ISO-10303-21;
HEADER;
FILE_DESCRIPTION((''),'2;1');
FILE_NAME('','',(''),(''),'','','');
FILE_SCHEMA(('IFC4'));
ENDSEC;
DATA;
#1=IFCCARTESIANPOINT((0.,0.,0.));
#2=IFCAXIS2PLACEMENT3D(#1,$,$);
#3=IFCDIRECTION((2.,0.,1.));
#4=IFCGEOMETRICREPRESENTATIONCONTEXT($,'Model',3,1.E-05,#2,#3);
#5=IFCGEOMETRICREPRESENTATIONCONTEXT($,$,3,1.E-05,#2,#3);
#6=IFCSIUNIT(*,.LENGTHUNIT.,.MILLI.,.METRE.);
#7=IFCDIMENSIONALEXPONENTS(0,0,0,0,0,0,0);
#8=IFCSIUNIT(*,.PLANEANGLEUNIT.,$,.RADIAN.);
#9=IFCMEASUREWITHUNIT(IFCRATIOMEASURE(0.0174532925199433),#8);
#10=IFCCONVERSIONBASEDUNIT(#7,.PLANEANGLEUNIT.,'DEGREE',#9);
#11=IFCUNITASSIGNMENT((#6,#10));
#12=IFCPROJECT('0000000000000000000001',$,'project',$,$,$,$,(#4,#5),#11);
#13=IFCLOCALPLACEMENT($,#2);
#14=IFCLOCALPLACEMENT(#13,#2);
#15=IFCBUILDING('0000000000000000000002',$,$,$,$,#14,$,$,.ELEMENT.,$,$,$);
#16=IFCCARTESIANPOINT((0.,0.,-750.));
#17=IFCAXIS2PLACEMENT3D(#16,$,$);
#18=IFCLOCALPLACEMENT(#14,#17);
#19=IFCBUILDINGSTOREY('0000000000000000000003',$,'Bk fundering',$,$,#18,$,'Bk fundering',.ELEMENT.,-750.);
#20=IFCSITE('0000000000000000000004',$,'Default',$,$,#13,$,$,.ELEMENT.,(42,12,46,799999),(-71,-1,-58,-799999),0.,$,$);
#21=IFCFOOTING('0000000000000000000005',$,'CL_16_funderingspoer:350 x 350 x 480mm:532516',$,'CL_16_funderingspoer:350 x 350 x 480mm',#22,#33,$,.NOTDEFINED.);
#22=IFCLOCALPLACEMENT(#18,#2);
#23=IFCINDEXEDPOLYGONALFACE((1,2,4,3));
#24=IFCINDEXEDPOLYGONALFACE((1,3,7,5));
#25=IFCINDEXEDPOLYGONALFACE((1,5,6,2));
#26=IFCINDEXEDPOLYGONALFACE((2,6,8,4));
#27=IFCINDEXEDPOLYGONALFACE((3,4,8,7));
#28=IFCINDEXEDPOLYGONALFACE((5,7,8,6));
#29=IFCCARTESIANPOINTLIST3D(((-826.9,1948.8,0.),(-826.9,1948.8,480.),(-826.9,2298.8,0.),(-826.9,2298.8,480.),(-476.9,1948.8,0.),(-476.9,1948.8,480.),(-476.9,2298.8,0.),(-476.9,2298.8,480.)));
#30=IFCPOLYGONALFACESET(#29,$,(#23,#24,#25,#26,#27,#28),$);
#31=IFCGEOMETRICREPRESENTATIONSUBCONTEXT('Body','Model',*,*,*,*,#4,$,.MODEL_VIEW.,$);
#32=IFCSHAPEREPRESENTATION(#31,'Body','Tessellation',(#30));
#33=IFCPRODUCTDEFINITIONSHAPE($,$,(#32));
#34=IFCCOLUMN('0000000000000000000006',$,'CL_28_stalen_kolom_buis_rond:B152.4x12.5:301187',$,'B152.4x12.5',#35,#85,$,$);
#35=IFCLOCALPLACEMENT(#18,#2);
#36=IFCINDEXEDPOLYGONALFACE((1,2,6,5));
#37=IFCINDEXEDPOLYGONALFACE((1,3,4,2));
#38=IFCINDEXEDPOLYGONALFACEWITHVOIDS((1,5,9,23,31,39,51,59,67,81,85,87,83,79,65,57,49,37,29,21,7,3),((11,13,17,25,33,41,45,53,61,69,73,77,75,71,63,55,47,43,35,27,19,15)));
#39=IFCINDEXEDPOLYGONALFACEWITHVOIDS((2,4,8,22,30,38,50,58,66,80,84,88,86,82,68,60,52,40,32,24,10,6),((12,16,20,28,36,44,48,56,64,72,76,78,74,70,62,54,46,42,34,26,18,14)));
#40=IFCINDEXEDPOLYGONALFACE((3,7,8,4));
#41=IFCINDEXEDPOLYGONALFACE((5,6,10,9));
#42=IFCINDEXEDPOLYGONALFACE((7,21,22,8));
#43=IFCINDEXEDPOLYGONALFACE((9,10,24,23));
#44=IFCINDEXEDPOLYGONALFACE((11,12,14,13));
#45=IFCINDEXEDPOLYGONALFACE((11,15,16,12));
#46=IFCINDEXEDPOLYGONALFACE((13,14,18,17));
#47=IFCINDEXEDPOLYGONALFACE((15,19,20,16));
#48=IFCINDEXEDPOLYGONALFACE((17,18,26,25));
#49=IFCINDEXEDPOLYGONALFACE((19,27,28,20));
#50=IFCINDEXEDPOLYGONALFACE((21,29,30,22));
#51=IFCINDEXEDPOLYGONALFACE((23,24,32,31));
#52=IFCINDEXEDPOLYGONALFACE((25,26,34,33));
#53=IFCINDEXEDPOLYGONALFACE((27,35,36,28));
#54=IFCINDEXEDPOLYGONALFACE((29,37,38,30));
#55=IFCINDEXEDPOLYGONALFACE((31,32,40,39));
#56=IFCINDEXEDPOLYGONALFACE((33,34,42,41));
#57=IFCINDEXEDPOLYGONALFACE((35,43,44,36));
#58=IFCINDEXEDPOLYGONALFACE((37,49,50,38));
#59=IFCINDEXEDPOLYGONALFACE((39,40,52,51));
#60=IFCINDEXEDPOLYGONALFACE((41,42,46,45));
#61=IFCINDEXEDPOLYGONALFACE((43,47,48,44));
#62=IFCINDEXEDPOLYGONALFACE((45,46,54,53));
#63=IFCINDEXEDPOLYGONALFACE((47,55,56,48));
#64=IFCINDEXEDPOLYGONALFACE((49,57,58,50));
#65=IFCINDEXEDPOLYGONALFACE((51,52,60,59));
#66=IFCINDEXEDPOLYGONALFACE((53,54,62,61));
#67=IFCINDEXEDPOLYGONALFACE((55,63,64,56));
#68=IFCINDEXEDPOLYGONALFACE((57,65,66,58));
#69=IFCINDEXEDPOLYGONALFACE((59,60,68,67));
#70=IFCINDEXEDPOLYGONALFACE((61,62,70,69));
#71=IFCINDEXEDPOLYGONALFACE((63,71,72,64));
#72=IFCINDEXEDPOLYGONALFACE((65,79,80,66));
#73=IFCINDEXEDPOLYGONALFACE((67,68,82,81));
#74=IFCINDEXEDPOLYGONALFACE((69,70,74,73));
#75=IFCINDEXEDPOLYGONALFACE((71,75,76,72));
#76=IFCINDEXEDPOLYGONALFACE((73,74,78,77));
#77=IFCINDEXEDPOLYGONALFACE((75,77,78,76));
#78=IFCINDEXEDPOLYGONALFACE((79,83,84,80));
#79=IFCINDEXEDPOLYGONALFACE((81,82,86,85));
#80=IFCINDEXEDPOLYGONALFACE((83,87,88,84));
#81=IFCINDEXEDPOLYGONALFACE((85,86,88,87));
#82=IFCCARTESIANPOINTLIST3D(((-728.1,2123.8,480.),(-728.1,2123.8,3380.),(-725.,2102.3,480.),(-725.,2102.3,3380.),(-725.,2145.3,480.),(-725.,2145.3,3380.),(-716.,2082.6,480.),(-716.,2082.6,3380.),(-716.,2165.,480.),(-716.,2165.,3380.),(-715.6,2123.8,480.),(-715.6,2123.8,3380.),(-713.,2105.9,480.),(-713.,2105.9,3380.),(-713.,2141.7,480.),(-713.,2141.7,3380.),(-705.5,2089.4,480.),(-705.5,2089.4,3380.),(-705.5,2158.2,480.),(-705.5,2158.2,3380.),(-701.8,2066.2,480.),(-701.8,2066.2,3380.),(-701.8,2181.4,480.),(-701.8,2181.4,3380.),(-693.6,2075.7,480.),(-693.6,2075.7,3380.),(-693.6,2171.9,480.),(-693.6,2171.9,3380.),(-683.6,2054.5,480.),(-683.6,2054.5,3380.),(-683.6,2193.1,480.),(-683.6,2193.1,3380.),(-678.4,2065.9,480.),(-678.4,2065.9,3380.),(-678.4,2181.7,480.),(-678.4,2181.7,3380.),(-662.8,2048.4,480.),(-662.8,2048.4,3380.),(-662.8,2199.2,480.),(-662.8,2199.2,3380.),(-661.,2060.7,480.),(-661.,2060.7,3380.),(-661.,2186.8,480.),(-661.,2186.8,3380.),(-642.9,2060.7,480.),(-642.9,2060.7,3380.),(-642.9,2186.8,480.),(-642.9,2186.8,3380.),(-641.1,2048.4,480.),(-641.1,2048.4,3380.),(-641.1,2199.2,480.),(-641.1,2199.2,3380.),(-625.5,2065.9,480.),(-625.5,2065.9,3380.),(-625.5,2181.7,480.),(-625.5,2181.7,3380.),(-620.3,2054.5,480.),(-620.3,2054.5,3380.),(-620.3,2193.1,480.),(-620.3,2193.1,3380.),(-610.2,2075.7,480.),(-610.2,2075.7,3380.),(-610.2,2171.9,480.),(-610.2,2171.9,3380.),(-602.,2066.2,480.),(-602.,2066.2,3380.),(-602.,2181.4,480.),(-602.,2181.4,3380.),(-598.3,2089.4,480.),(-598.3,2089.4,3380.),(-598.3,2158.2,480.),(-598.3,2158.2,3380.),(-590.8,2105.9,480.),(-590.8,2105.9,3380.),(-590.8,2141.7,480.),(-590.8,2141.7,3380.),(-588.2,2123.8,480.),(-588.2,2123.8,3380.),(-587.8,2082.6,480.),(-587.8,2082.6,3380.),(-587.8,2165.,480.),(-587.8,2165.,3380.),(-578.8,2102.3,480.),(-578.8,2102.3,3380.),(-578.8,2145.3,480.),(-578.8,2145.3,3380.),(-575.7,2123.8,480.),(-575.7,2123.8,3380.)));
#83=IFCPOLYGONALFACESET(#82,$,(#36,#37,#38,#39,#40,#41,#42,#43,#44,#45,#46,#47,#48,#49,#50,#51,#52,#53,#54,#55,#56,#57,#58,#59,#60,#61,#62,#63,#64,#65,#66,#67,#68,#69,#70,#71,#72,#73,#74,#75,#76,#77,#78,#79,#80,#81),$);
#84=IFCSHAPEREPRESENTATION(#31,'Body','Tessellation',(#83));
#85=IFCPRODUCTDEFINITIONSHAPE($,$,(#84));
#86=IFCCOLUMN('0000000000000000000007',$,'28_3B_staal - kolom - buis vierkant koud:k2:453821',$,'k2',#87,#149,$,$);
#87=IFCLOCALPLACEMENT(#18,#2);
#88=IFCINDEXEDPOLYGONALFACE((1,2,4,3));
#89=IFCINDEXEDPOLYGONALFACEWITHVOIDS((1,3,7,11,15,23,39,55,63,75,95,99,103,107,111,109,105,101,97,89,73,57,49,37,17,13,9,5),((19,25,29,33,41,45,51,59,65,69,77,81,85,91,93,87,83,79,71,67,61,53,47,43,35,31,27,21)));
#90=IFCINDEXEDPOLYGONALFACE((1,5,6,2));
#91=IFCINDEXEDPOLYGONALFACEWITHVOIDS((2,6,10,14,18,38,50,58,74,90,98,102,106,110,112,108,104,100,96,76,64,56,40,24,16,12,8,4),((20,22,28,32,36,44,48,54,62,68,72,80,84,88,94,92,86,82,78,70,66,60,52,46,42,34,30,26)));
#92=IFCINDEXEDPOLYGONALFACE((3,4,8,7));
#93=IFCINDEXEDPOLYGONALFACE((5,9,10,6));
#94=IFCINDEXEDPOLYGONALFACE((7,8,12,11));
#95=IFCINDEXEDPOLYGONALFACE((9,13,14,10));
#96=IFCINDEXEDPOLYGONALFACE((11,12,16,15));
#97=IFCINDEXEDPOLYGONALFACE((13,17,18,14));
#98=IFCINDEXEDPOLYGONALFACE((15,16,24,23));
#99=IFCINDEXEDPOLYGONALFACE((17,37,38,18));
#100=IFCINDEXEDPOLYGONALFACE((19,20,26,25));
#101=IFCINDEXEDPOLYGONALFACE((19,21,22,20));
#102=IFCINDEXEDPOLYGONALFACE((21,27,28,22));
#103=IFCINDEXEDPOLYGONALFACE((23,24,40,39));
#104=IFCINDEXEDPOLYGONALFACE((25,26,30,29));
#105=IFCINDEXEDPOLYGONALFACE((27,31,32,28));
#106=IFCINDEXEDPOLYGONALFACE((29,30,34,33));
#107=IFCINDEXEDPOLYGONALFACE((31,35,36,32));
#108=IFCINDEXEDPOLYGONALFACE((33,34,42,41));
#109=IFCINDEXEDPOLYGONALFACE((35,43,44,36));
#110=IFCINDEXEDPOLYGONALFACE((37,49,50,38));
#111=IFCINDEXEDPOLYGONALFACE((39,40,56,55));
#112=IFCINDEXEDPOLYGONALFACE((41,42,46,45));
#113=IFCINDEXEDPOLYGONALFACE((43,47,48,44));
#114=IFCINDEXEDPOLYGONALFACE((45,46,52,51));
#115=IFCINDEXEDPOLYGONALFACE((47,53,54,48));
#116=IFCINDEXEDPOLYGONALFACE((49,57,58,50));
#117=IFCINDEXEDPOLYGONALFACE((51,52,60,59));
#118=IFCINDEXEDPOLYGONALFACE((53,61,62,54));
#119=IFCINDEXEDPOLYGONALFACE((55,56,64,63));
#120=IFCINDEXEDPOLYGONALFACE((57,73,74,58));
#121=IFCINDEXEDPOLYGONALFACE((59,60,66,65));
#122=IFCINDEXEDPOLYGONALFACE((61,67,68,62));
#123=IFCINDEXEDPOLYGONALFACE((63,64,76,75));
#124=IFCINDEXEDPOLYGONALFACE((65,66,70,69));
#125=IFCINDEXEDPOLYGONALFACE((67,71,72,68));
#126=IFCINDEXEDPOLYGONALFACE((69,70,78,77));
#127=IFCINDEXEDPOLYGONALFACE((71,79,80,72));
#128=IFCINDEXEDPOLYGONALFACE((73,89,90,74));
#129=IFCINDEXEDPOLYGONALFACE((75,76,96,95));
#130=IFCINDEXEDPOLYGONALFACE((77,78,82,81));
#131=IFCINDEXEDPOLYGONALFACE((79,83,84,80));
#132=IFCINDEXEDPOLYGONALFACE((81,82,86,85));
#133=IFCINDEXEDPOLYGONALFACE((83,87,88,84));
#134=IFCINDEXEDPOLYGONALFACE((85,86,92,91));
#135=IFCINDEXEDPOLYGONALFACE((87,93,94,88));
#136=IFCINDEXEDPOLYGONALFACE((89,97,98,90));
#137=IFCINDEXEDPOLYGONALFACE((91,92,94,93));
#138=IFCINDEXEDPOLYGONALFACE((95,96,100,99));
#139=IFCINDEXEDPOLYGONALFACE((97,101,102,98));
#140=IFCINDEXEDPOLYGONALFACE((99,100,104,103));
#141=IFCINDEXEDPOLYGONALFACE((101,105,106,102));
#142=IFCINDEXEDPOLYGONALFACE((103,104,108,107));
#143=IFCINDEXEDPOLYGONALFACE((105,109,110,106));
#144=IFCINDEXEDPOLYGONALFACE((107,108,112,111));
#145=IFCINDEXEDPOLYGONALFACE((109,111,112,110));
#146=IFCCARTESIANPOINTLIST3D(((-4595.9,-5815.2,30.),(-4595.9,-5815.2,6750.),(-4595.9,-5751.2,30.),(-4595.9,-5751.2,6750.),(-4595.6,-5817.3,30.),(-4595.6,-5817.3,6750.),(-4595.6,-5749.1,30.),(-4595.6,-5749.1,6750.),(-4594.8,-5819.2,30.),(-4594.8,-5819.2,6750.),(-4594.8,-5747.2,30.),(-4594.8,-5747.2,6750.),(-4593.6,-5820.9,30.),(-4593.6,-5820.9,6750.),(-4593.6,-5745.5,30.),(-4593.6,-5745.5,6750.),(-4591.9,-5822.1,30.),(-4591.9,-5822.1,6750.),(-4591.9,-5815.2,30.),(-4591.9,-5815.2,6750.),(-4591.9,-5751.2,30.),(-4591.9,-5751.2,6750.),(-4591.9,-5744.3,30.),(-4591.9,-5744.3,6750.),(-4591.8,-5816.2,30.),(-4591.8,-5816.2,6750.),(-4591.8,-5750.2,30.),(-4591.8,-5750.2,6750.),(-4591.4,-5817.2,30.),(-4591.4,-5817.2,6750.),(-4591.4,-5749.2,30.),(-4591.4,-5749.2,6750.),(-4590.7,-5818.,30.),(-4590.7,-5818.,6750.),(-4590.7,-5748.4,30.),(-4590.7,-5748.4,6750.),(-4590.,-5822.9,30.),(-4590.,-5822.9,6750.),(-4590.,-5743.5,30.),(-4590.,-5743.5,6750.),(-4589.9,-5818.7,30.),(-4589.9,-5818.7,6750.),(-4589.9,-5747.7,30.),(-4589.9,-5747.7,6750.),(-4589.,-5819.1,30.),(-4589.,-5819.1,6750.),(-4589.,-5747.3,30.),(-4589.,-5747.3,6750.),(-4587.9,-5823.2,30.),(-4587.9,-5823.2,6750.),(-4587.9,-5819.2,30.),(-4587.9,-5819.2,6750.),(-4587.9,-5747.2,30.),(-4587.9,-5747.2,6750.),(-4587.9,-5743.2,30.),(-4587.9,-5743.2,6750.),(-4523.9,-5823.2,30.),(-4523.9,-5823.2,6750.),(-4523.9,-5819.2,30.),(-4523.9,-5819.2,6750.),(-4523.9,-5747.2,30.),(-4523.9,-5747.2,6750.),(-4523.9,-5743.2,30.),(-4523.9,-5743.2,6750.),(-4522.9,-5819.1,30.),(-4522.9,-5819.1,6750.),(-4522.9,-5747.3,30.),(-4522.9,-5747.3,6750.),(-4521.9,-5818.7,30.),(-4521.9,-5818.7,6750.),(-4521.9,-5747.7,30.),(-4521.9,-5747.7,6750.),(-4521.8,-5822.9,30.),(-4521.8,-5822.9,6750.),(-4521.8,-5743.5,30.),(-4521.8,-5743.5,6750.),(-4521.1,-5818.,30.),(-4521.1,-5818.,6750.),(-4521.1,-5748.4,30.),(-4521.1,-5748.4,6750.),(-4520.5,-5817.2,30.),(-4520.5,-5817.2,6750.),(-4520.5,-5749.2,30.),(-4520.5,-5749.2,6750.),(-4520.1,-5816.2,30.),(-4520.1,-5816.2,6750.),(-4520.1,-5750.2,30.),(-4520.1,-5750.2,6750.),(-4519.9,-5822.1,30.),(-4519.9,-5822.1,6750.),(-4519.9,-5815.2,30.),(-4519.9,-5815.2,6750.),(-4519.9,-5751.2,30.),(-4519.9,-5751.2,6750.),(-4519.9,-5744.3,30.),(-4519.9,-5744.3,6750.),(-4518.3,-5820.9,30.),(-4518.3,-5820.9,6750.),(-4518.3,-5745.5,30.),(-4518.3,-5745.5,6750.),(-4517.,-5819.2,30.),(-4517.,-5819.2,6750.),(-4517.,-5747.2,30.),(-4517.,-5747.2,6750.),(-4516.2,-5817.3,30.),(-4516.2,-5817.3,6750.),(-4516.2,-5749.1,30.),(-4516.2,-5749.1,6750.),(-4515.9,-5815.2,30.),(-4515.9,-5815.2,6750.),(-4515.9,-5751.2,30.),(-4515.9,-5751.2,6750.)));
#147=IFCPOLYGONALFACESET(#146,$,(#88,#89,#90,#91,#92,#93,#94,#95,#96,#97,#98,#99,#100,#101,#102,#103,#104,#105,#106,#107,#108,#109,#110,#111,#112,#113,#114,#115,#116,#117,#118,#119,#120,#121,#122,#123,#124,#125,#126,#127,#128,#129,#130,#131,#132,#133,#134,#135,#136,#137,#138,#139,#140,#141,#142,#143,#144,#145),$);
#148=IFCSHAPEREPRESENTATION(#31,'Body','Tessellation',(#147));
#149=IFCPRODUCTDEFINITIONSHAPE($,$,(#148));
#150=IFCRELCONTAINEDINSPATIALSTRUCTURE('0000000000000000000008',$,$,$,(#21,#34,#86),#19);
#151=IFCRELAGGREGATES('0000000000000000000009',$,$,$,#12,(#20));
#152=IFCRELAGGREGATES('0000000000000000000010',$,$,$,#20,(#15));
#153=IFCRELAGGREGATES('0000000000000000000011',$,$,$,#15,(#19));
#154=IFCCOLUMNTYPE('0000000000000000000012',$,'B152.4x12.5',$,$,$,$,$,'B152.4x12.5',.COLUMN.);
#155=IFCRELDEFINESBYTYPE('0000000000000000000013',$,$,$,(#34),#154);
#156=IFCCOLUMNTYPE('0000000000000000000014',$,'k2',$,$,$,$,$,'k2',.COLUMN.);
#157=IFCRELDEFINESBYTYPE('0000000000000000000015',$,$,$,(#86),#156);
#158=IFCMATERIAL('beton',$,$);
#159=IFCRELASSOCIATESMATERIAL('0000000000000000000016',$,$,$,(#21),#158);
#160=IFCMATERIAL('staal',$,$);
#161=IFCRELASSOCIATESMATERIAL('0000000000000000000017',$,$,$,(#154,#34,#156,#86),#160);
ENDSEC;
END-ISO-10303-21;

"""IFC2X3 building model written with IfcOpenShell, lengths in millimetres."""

from ifc_helpers import new_model, entity, si_unit, converted_unit, direction, frame, frame_2d, origin, place, context, subcontext, project, spatial, polyline, circle_curve, parameter, trimmed, segment, composite_curve, rectangle, outline, extrude, source, transform, mapped, material, type_object, type_shapes, element, save


model = new_model("IFC2X3")

# Units and contexts
model_context = context("Model", 3, precision=1e-05, world=origin(), true_north=direction((2.0, 0.0, 1.0)))
context_of_model = context(None, 3, precision=1e-05, world=origin(), true_north=direction((2.0, 0.0, 1.0)))
body_context = subcontext(model_context, "Body", "Model", "MODEL_VIEW")
ifc_project = project(units=[si_unit("LENGTHUNIT", "METRE", prefix="MILLI"), converted_unit("PLANEANGLEUNIT", "DEGREE", entity("IfcRatioMeasure", 0.0174532925199433), si_unit("PLANEANGLEUNIT", "RADIAN"), dimensions=[0, 0, 0, 0, 0, 0, 0])], contexts=[model_context, context_of_model])

# Site, building, storey
site_placement = place(None, origin())
site = spatial("IfcSite", under=ifc_project, at=site_placement, Name="Default", CompositionType="ELEMENT", RefLatitude=(42, 12, 46, 799999), RefLongitude=(-71, -1, -58, -799999), RefElevation=0.0)
building_placement = place(site_placement, origin())
building = spatial("IfcBuilding", under=site, at=building_placement, CompositionType="ELEMENT")
storey_placement = place(building_placement, frame((0.0, 0.0, -750.0)))
storey = spatial("IfcBuildingStorey", under=building, at=storey_placement, Name="Bk fundering", LongName="Bk fundering", CompositionType="ELEMENT", Elevation=-750.0)

# Footing
ifc_material_1 = material(Name="beton")
footing_placement = place(storey_placement, origin())
element("IfcFooting", 1, at=footing_placement, inside=storey, material=ifc_material_1, Name="CL_16_funderingspoer:350 x 350 x 480mm:532516", ObjectType="CL_16_funderingspoer:350 x 350 x 480mm", PredefinedType="NOTDEFINED", context=body_context, shape_type="SweptSolid", body=[
    extrude(rectangle(XDim=350.0, YDim=350.0, at=frame_2d((0.0, 0.0), x_axis=(1.0, 0.0))), frame((-651.9, 2123.8, 0.0), z_axis=(0.0, 0.0, 1.0), x_axis=(0.0, 1.0, 0.0)), (0.0, 0.0, 1.0), 480.0),
])

# Columns
ifc_material_2 = material(Name="staal")
column_type_1 = type_object("IfcColumnType", Name="B152.4x12.5", ElementType="B152.4x12.5", PredefinedType="COLUMN", material=ifc_material_2)
shared_shape_1 = source(origin(), body_context, "Body", "SweptSolid", [
    extrude(outline(composite_curve([segment(trimmed(circle_curve(frame_2d((-651.9, 2123.8), x_axis=(1.0, 0.0)), 76.2), [parameter(0.0)], [parameter(180.0)], True, "PARAMETER"), True, "CONTINUOUS"), segment(trimmed(circle_curve(frame_2d((-651.9, 2123.8), x_axis=(1.0, 0.0)), 76.2), [parameter(180.0)], [parameter(0.0)], True, "PARAMETER"), True, "CONTINUOUS")], self_intersect=False), holes=[composite_curve([segment(trimmed(circle_curve(frame_2d((-651.9, 2123.8), x_axis=(1.0, 0.0)), 63.7), [parameter(180.0)], [parameter(0.0)], True, "PARAMETER"), False, "CONTINUOUS"), segment(trimmed(circle_curve(frame_2d((-651.9, 2123.8), x_axis=(1.0, 0.0)), 63.7), [parameter(0.0)], [parameter(180.0)], True, "PARAMETER"), False, "CONTINUOUS")], self_intersect=False)]), origin(), (0.0, 0.0, 1.0), 2900.0),
])
type_shapes(column_type_1, [shared_shape_1])
column_1_placement = place(storey_placement, frame((0.0, 0.0, 480.0)))
element("IfcColumn", 2, at=column_1_placement, inside=storey, type_object=column_type_1, material=ifc_material_2, Name="CL_28_stalen_kolom_buis_rond:B152.4x12.5:301187", ObjectType="B152.4x12.5", context=body_context, shape_type="MappedRepresentation", body=[
    mapped(shared_shape_1, transform((0.0, 0.0, 0.0), scale=1.0)),
])
column_type_2 = type_object("IfcColumnType", Name="k2", ElementType="k2", PredefinedType="COLUMN", material=ifc_material_2)
shared_shape_2 = source(origin(), body_context, "Body", "SweptSolid", [
    extrude(outline(composite_curve([segment(trimmed(circle_curve(frame_2d((32.0, -32.0), x_axis=(1.0, 0.0)), 8.0), [parameter(270.0)], [parameter(0.0)], True, "PARAMETER"), True, "CONTINUOUS"), segment(polyline([(40.0, -32.0), (40.0, 32.0)]), True, "CONTINUOUS"), segment(trimmed(circle_curve(frame_2d((32.0, 32.0), x_axis=(1.0, 0.0)), 8.0), [parameter(0.0)], [parameter(90.0)], True, "PARAMETER"), True, "CONTINUOUS"), segment(polyline([(32.0, 40.0), (-32.0, 40.0)]), True, "CONTINUOUS"), segment(trimmed(circle_curve(frame_2d((-32.0, 32.0), x_axis=(1.0, 0.0)), 8.0), [parameter(90.0)], [parameter(180.0)], True, "PARAMETER"), True, "CONTINUOUS"), segment(polyline([(-40.0, 32.0), (-40.0, -32.0)]), True, "CONTINUOUS"), segment(trimmed(circle_curve(frame_2d((-32.0, -32.0), x_axis=(1.0, 0.0)), 8.0), [parameter(180.0)], [parameter(270.0)], True, "PARAMETER"), True, "CONTINUOUS"), segment(polyline([(-32.0, -40.0), (32.0, -40.0)]), True, "CONTINUOUS")], self_intersect=False), holes=[composite_curve([segment(polyline([(32.0, -36.0), (-32.0, -36.0)]), True, "CONTINUOUS"), segment(trimmed(circle_curve(frame_2d((-32.0, -32.0), x_axis=(1.0, 0.0)), 4.0), [parameter(180.0)], [parameter(270.0)], True, "PARAMETER"), False, "CONTINUOUS"), segment(polyline([(-36.0, -32.0), (-36.0, 32.0)]), True, "CONTINUOUS"), segment(trimmed(circle_curve(frame_2d((-32.0, 32.0), x_axis=(1.0, 0.0)), 4.0), [parameter(90.0)], [parameter(180.0)], True, "PARAMETER"), False, "CONTINUOUS"), segment(polyline([(-32.0, 36.0), (32.0, 36.0)]), True, "CONTINUOUS"), segment(trimmed(circle_curve(frame_2d((32.0, 32.0), x_axis=(1.0, 0.0)), 4.0), [parameter(360.0)], [parameter(90.0)], True, "PARAMETER"), False, "CONTINUOUS"), segment(polyline([(36.0, 32.0), (36.0, -32.0)]), True, "CONTINUOUS"), segment(trimmed(circle_curve(frame_2d((32.0, -32.0), x_axis=(1.0, 0.0)), 4.0), [parameter(270.0)], [parameter(0.0)], True, "PARAMETER"), False, "CONTINUOUS")], self_intersect=False)]), frame((-4555.9, -5783.2, -720.0)), (0.0, 0.0, 1.0), 6720.0),
])
type_shapes(column_type_2, [shared_shape_2])
column_2_placement = place(storey_placement, frame((0.0, 0.0, 750.0)))
element("IfcColumn", 3, at=column_2_placement, inside=storey, type_object=column_type_2, material=ifc_material_2, Name="28_3B_staal - kolom - buis vierkant koud:k2:453821", ObjectType="k2", context=body_context, shape_type="MappedRepresentation", body=[
    mapped(shared_shape_2, transform((0.0, 0.0, 0.0), scale=1.0)),
])

save(model, "model.ifc")
